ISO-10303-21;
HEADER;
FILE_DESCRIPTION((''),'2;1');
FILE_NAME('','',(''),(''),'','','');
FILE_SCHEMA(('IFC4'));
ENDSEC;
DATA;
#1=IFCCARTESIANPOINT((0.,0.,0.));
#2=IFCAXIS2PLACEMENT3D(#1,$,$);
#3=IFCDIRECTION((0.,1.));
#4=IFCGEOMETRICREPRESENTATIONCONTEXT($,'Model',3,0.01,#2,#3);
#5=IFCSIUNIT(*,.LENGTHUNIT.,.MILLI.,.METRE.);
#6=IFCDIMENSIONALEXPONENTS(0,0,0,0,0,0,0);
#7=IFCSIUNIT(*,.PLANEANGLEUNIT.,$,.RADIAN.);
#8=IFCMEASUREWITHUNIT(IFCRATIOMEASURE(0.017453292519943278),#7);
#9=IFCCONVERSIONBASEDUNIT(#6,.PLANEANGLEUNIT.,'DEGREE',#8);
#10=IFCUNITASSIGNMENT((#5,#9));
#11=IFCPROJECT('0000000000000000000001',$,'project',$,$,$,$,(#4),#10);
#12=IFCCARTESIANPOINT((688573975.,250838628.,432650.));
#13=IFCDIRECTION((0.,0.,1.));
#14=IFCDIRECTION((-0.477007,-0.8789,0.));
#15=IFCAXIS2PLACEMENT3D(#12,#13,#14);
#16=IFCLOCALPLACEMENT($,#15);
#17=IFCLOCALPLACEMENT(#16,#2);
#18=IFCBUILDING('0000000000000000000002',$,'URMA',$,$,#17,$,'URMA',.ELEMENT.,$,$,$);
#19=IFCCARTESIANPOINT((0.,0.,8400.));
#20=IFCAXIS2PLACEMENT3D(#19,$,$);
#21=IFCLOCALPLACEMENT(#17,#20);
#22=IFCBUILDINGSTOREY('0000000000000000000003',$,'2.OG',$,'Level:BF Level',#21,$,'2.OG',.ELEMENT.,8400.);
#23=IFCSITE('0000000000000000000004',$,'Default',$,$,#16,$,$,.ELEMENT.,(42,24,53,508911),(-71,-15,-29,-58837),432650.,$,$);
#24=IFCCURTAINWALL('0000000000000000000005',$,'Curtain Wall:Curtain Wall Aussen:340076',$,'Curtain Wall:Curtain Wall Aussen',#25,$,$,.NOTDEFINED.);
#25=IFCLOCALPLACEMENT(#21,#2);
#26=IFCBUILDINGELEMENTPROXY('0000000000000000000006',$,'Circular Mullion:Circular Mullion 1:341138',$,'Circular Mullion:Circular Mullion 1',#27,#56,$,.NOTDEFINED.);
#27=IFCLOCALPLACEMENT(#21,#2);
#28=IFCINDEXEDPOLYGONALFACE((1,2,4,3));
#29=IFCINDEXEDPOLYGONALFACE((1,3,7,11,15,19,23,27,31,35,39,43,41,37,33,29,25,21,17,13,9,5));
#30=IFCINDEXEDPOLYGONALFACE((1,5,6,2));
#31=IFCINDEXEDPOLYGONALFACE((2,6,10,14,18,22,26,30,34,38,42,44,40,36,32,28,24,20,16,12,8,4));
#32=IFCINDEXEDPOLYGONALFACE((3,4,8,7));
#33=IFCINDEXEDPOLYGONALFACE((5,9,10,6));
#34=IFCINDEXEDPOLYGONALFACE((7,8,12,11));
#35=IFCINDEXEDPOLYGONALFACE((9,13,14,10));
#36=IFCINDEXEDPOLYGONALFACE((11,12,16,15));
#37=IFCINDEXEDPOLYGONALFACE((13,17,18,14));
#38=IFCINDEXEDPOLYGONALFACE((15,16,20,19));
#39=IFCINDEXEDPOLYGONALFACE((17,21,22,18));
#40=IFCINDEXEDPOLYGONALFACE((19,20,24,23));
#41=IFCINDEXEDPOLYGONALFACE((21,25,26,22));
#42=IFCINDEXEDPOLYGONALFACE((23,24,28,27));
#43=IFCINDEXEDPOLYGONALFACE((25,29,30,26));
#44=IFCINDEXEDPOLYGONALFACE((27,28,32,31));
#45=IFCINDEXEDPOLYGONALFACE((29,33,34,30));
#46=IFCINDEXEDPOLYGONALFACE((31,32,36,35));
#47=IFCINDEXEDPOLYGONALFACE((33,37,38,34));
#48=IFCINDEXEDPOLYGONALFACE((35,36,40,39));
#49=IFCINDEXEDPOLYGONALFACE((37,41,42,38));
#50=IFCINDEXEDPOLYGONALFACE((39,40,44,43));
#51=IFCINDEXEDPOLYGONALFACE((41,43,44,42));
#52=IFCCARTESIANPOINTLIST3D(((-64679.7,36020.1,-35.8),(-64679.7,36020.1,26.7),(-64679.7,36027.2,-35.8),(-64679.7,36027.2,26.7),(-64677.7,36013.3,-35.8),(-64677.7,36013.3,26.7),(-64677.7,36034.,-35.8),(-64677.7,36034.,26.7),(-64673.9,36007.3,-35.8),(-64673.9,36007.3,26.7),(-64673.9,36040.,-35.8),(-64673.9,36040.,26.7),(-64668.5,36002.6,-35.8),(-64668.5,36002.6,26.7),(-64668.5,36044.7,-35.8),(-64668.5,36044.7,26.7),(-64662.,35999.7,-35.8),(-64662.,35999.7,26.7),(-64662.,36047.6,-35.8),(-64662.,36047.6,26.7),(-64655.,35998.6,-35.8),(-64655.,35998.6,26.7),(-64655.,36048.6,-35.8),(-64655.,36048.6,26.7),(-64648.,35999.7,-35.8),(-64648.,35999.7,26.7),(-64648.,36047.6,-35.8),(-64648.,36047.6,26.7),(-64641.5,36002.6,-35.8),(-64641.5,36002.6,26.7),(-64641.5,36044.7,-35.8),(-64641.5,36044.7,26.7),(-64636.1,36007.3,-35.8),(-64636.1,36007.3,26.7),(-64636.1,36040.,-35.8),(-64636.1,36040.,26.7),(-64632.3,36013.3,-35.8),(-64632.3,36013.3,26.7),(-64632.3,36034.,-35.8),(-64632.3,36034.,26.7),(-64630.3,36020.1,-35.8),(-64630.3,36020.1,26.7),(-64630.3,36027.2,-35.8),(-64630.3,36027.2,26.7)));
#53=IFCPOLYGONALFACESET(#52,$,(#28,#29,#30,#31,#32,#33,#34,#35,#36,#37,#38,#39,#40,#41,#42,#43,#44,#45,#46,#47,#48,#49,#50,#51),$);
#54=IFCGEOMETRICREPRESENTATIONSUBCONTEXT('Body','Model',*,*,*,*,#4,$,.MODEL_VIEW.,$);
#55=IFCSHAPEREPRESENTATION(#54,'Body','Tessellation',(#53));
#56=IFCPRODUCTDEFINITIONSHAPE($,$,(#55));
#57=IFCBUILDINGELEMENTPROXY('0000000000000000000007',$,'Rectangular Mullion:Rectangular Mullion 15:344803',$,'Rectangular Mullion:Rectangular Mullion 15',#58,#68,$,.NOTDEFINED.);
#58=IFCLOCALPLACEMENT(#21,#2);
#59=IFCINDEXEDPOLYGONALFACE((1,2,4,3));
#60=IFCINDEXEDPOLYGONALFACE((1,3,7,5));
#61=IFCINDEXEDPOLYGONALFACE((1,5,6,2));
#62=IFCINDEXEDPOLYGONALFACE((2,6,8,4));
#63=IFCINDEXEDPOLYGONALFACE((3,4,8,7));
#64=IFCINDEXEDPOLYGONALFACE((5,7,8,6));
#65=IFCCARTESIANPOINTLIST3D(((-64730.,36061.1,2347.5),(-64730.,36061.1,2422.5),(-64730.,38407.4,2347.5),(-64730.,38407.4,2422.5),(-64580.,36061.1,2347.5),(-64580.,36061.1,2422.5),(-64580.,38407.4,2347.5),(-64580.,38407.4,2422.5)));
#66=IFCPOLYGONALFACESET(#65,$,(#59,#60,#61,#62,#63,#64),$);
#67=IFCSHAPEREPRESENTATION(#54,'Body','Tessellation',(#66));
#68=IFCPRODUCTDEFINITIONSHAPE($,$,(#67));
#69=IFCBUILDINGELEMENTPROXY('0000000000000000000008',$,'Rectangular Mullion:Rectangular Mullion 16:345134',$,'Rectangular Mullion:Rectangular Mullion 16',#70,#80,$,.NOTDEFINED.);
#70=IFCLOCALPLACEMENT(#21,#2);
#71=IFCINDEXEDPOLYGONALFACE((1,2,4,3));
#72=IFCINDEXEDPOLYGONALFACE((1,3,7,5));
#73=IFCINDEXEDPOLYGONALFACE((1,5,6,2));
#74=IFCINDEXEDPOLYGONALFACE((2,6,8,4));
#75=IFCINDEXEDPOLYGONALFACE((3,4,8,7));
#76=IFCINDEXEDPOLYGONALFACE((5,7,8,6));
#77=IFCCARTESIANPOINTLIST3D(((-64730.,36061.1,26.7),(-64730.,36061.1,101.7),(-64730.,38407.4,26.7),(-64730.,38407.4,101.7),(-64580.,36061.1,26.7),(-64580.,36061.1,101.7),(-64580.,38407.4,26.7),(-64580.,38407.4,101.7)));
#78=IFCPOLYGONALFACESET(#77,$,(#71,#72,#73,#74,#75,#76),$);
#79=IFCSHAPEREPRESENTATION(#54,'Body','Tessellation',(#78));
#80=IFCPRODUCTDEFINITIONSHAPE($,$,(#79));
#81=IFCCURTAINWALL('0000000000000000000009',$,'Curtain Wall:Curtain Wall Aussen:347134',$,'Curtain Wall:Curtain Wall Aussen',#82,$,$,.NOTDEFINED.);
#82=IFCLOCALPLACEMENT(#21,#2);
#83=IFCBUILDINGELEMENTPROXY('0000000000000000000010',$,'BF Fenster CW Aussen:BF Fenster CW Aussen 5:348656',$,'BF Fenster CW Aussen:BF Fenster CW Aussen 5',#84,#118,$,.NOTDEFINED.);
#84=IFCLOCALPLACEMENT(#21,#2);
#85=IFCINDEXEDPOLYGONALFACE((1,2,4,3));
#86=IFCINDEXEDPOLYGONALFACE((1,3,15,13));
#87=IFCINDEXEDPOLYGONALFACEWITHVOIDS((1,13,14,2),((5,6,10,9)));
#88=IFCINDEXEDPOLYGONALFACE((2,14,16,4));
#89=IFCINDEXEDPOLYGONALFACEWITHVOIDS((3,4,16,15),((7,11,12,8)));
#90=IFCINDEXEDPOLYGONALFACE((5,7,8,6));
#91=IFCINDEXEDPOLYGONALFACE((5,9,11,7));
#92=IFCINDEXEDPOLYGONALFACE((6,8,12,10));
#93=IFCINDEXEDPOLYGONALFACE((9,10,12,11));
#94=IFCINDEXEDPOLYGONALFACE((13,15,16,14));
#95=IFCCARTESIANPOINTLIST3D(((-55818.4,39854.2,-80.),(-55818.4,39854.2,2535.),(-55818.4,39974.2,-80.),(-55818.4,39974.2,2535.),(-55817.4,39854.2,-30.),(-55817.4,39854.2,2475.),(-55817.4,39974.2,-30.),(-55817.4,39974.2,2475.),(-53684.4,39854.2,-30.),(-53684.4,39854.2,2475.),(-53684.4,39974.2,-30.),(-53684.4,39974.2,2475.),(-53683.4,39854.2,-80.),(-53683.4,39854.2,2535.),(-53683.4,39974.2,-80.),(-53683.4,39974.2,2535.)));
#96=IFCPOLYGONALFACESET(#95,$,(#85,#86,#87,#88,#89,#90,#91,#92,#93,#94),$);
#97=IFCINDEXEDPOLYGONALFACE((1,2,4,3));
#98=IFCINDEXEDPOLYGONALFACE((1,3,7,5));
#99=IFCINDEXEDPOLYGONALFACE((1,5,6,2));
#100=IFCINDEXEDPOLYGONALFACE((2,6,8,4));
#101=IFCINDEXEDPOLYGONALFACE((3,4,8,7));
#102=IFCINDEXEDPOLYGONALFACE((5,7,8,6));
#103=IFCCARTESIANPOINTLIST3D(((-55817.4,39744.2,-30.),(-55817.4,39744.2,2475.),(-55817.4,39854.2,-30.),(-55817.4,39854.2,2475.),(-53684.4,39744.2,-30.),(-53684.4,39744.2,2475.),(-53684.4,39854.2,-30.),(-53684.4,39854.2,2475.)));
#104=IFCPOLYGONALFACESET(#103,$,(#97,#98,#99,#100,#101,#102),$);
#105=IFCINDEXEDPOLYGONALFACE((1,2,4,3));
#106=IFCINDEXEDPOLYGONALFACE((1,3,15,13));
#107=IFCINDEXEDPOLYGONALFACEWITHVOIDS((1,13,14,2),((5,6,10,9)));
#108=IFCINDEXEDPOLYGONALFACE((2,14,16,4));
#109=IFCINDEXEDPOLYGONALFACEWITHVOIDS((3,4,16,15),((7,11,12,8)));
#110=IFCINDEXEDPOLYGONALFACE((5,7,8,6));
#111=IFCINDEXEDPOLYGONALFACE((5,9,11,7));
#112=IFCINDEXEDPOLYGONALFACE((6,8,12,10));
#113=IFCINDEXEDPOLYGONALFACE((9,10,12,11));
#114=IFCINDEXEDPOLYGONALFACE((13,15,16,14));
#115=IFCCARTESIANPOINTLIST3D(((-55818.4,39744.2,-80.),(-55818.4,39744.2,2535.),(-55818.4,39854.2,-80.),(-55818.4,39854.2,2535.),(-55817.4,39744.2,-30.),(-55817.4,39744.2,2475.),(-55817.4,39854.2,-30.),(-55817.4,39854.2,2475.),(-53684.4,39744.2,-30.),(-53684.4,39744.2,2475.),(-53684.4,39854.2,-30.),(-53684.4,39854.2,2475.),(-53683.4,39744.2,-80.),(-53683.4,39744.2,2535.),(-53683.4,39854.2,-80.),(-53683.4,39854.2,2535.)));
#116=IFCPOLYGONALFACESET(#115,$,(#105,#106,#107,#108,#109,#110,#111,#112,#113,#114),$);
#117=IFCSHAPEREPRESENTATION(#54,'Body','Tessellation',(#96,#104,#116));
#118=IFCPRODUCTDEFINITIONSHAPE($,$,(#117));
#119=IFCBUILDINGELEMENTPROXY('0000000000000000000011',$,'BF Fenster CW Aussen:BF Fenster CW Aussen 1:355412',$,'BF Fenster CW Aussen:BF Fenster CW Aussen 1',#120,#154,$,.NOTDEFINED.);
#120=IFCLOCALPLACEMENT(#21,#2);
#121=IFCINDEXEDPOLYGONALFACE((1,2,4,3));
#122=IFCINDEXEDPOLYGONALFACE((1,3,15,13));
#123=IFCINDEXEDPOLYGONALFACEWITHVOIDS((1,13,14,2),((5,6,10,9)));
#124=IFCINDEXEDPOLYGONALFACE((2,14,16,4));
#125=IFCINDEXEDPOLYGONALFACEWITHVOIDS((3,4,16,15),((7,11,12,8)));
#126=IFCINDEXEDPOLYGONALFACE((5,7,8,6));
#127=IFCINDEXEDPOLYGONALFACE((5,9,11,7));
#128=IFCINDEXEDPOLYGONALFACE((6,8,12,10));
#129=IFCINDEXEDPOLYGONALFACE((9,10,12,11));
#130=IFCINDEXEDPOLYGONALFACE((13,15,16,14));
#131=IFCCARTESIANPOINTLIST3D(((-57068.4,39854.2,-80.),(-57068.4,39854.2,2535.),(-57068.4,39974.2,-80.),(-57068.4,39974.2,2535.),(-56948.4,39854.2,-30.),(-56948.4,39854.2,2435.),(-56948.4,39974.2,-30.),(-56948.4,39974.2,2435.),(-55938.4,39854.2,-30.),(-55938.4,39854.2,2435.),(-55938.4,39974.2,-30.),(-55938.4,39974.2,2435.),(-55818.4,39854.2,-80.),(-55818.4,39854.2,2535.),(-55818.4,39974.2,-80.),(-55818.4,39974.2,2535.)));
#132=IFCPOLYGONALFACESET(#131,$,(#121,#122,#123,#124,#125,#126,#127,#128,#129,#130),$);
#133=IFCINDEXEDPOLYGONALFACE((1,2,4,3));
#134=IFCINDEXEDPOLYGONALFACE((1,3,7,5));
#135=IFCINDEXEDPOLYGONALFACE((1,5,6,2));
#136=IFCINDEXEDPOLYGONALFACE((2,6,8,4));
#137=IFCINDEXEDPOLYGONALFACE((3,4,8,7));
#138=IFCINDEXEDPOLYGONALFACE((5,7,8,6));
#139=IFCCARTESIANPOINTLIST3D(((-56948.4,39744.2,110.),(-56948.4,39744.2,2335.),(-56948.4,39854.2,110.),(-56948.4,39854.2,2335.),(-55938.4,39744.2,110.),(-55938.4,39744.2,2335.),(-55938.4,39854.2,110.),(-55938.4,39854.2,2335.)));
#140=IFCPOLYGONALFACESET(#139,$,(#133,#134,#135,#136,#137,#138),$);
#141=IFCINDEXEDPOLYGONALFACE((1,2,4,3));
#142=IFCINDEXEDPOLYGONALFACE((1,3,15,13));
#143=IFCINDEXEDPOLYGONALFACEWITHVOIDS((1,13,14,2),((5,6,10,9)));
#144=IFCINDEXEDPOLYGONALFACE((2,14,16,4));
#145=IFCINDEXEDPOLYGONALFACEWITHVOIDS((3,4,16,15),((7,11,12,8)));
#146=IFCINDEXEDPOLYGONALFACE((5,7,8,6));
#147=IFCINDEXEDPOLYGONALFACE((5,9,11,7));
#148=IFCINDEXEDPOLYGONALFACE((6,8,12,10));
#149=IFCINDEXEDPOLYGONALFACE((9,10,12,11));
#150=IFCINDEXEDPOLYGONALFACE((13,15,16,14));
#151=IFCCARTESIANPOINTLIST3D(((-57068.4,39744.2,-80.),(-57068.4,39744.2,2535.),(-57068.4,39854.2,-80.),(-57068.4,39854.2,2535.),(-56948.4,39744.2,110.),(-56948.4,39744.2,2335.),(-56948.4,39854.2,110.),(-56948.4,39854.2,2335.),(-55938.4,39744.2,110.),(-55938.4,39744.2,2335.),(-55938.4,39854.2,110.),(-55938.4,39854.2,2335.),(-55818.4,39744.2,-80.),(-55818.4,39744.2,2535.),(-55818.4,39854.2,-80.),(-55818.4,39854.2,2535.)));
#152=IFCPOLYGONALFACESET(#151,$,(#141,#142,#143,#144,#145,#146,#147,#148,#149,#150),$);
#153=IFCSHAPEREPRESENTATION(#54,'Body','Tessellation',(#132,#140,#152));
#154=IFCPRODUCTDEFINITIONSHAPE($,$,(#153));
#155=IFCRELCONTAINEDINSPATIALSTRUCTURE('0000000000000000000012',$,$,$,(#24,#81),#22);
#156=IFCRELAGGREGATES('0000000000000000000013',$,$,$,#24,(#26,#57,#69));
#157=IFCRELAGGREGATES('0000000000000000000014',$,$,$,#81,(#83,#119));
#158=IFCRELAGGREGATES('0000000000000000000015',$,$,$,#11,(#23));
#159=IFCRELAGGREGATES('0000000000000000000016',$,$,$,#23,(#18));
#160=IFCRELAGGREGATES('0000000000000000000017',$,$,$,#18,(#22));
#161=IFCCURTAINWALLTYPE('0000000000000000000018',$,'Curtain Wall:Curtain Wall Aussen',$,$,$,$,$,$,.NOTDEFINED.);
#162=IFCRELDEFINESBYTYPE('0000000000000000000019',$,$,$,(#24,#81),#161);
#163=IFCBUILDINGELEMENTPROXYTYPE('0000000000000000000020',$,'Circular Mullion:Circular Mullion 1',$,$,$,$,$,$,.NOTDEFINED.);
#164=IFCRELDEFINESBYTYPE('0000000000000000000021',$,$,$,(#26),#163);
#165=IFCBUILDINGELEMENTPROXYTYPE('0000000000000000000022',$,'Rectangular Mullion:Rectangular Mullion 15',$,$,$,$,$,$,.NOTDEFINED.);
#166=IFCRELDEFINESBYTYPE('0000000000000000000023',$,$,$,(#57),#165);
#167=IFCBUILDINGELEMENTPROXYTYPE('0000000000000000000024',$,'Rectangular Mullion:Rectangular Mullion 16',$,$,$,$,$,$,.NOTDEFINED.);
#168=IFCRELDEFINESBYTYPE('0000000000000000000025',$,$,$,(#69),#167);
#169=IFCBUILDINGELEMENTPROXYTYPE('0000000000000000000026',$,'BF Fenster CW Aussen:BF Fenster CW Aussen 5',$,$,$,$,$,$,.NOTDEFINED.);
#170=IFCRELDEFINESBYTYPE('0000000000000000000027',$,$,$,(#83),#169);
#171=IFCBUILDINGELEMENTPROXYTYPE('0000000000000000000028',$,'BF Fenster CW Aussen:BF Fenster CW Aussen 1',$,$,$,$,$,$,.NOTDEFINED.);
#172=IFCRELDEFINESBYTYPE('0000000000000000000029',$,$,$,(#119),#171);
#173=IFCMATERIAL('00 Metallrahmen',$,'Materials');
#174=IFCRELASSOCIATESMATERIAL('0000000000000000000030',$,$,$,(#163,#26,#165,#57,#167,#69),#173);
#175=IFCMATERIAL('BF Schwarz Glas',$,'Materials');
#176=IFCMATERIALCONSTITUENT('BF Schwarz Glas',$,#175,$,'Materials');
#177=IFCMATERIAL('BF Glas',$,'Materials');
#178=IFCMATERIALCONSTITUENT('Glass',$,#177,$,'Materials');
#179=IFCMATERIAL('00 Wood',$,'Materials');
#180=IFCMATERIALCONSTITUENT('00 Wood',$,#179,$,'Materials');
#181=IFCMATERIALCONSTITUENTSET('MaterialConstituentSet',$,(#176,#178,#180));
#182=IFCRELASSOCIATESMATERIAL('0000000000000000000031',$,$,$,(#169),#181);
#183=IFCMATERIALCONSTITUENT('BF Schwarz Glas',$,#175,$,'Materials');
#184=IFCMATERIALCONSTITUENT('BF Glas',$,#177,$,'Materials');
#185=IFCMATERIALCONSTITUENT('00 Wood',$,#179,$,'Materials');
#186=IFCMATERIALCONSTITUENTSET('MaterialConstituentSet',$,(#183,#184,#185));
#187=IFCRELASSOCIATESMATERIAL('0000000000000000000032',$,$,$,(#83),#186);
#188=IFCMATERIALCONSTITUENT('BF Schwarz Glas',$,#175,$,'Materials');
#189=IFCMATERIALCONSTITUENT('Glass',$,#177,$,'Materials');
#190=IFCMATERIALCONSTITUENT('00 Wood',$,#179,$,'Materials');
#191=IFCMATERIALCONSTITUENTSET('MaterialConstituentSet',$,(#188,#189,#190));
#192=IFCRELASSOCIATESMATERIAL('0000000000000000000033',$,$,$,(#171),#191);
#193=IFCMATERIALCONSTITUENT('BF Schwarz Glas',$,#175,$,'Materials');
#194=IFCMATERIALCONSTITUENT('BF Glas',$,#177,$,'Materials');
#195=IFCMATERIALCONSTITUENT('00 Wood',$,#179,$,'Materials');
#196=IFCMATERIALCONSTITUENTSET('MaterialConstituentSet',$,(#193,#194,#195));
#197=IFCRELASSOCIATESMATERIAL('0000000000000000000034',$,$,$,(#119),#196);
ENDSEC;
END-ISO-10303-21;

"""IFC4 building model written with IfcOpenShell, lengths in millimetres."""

from ifc_helpers import new_model, entity, si_unit, converted_unit, direction, frame, origin, place, context, subcontext, project, spatial, arc, indexed_curve, outline, extrude, source, transform, mapped, material, constituent, constituent_set, type_object, type_shapes, element, aggregate, save


model = new_model("IFC4")

# Units and contexts
model_context = context("Model", 3, precision=0.01, world=origin(), true_north=direction((0.0, 1.0)))
body_context = subcontext(model_context, "Body", "Model", "MODEL_VIEW")
ifc_project = project(units=[si_unit("LENGTHUNIT", "METRE", prefix="MILLI"), converted_unit("PLANEANGLEUNIT", "DEGREE", entity("IfcRatioMeasure", 0.017453292519943278), si_unit("PLANEANGLEUNIT", "RADIAN"), dimensions=[0, 0, 0, 0, 0, 0, 0])], contexts=[model_context])

# Site, building, storey
site_placement = place(None, frame((688573975.0, 250838628.0, 432650.0), z_axis=(0.0, 0.0, 1.0), x_axis=(-0.477007, -0.8789, 0.0)))
site = spatial("IfcSite", under=ifc_project, at=site_placement, Name="Default", CompositionType="ELEMENT", RefLatitude=(42, 24, 53, 508911), RefLongitude=(-71, -15, -29, -58837), RefElevation=432650.0)
building_placement = place(site_placement, origin())
building = spatial("IfcBuilding", under=site, at=building_placement, Name="URMA", LongName="URMA", CompositionType="ELEMENT")
storey_placement = place(building_placement, frame((0.0, 0.0, 8400.0)))
storey = spatial("IfcBuildingStorey", under=building, at=storey_placement, Name="2.OG", ObjectType="Level:BF Level", LongName="2.OG", CompositionType="ELEMENT", Elevation=8400.0)

# Shared definitions
curtain_wall_type = type_object("IfcCurtainWallType", Name="Curtain Wall:Curtain Wall Aussen", PredefinedType="NOTDEFINED")

# Curtain walls, building element proxies
curtain_wall_1_placement = place(storey_placement, frame((0.0, 0.0, -8400.0)))
curtain_wall_1 = element("IfcCurtainWall", 1, at=curtain_wall_1_placement, inside=storey, type_object=curtain_wall_type, Name="Curtain Wall:Curtain Wall Aussen:340076", ObjectType="Curtain Wall:Curtain Wall Aussen", PredefinedType="NOTDEFINED")
ifc_material_1 = material(Name="00 Metallrahmen", Category="Materials")
building_element_proxy_type_1 = type_object("IfcBuildingElementProxyType", Name="Circular Mullion:Circular Mullion 1", PredefinedType="NOTDEFINED", material=ifc_material_1)
shared_shape_1 = source(origin(), body_context, "Body", "SweptSolid", [
    extrude(outline(indexed_curve([(25.0, 0.0), (0.0, 25.0), (-25.0, 0.0), (0.0, -25.0)], segments=[arc(1, 2, 3), arc(3, 4, 1)], self_intersect=False)), frame((0.0, 0.0, -62.5)), (0.0, 0.0, 1.0), 62.5),
])
type_shapes(building_element_proxy_type_1, [shared_shape_1])
proxy_1_placement = place(storey_placement, frame((-64655.0, 36023.6, -35.8), z_axis=(0.0, 0.0, -1.0), x_axis=(0.0, -1.0, 0.0)))
proxy_1 = element("IfcBuildingElementProxy", 2, at=proxy_1_placement, type_object=building_element_proxy_type_1, material=ifc_material_1, Name="Circular Mullion:Circular Mullion 1:341138", ObjectType="Circular Mullion:Circular Mullion 1", PredefinedType="NOTDEFINED", context=body_context, shape_type="MappedRepresentation", body=[
    mapped(shared_shape_1, transform((0.0, 0.0, 0.0), scale=1.0)),
])
building_element_proxy_type_2 = type_object("IfcBuildingElementProxyType", Name="Rectangular Mullion:Rectangular Mullion 15", PredefinedType="NOTDEFINED", material=ifc_material_1)
shared_shape_2 = source(origin(), body_context, "Body", "SweptSolid", [
    extrude(outline(indexed_curve([(-37.5, -75.0), (37.5, -75.0), (37.5, 75.0), (-37.5, 75.0), (-37.5, -75.0)], self_intersect=False)), frame((-37.5, 0.0, -2346.2), z_axis=(0.0, 0.0, 1.0), x_axis=(-1.0, 0.0, 0.0)), (0.0, 0.0, 1.0), 2346.2),
])
type_shapes(building_element_proxy_type_2, [shared_shape_2])
proxy_2_placement = place(storey_placement, frame((-64655.0, 36061.1, 2422.5), z_axis=(0.0, -1.0, 0.0), x_axis=(0.0, 0.0, 1.0)))
proxy_2 = element("IfcBuildingElementProxy", 3, at=proxy_2_placement, type_object=building_element_proxy_type_2, material=ifc_material_1, Name="Rectangular Mullion:Rectangular Mullion 15:344803", ObjectType="Rectangular Mullion:Rectangular Mullion 15", PredefinedType="NOTDEFINED", context=body_context, shape_type="MappedRepresentation", body=[
    mapped(shared_shape_2, transform((0.0, 0.0, 0.0), scale=1.0)),
])
building_element_proxy_type_3 = type_object("IfcBuildingElementProxyType", Name="Rectangular Mullion:Rectangular Mullion 16", PredefinedType="NOTDEFINED", material=ifc_material_1)
shared_shape_3 = source(origin(), body_context, "Body", "SweptSolid", [
    extrude(outline(indexed_curve([(-37.5, -75.0), (37.5, -75.0), (37.5, 75.0), (-37.5, 75.0), (-37.5, -75.0)], self_intersect=False)), frame((37.5, 0.0, -2346.2), z_axis=(0.0, 0.0, 1.0), x_axis=(-1.0, 0.0, 0.0)), (0.0, 0.0, 1.0), 2346.2),
])
type_shapes(building_element_proxy_type_3, [shared_shape_3])
proxy_3_placement = place(storey_placement, frame((-64655.0, 36061.1, 26.7), z_axis=(0.0, -1.0, 0.0), x_axis=(0.0, 0.0, 1.0)))
proxy_3 = element("IfcBuildingElementProxy", 4, at=proxy_3_placement, type_object=building_element_proxy_type_3, material=ifc_material_1, Name="Rectangular Mullion:Rectangular Mullion 16:345134", ObjectType="Rectangular Mullion:Rectangular Mullion 16", PredefinedType="NOTDEFINED", context=body_context, shape_type="MappedRepresentation", body=[
    mapped(shared_shape_3, transform((0.0, 0.0, 0.0), scale=1.0)),
])
aggregate(curtain_wall_1, [proxy_1, proxy_2, proxy_3])
curtain_wall_2_placement = place(storey_placement, frame((0.0, 0.0, -8400.0)))
curtain_wall_2 = element("IfcCurtainWall", 5, at=curtain_wall_2_placement, inside=storey, type_object=curtain_wall_type, Name="Curtain Wall:Curtain Wall Aussen:347134", ObjectType="Curtain Wall:Curtain Wall Aussen", PredefinedType="NOTDEFINED")
ifc_material_2 = material(Name="BF Schwarz Glas", Category="Materials")
ifc_constituent_1 = constituent(ifc_material_2, Name="BF Schwarz Glas", Category="Materials")
ifc_material_3 = material(Name="BF Glas", Category="Materials")
ifc_constituent_2 = constituent(ifc_material_3, Name="BF Glas", Category="Materials")
ifc_material_4 = material(Name="00 Wood", Category="Materials")
ifc_constituent_3 = constituent(ifc_material_4, Name="00 Wood", Category="Materials")
ifc_constituent_set_1 = constituent_set(constituents=[ifc_constituent_1, ifc_constituent_2, ifc_constituent_3], Name="MaterialConstituentSet")
ifc_constituent_4 = constituent(ifc_material_2, Name="BF Schwarz Glas", Category="Materials")
ifc_constituent_5 = constituent(ifc_material_3, Name="Glass", Category="Materials")
ifc_constituent_6 = constituent(ifc_material_4, Name="00 Wood", Category="Materials")
ifc_constituent_set_2 = constituent_set(constituents=[ifc_constituent_4, ifc_constituent_5, ifc_constituent_6], Name="MaterialConstituentSet")
building_element_proxy_type_4 = type_object("IfcBuildingElementProxyType", Name="BF Fenster CW Aussen:BF Fenster CW Aussen 5", PredefinedType="NOTDEFINED", material=ifc_constituent_set_2)
shared_shape_4 = source(origin(), body_context, "Body", "SweptSolid", [
    extrude(outline(indexed_curve([(-1067.5, -1307.5), (1067.5, -1307.5), (1067.5, 1307.5), (-1067.5, 1307.5), (-1067.5, -1307.5)], self_intersect=False), holes=[indexed_curve([(-1066.5, -1247.5), (-1066.5, 1257.5), (1066.5, 1257.5), (1066.5, -1247.5), (-1066.5, -1247.5)], self_intersect=False)]), frame((0.0, -120.0, 1307.5), z_axis=(0.0, 1.0, 0.0), x_axis=(1.0, 0.0, 0.0)), (0.0, 0.0, 1.0), 120.0),
    extrude(outline(indexed_curve([(-55.0, -1066.5), (55.0, -1066.5), (55.0, 1066.5), (-55.0, 1066.5), (-55.0, -1066.5)], self_intersect=False)), frame((0.0, 55.0, 50.0), z_axis=(0.0, 0.0, 1.0), x_axis=(0.0, 1.0, 0.0)), (0.0, 0.0, 1.0), 2505.0),
    extrude(outline(indexed_curve([(-1067.5, -1307.5), (1067.5, -1307.5), (1067.5, 1307.5), (-1067.5, 1307.5), (-1067.5, -1307.5)], self_intersect=False), holes=[indexed_curve([(-1066.5, -1247.5), (-1066.5, 1257.5), (1066.5, 1257.5), (1066.5, -1247.5), (-1066.5, -1247.5)], self_intersect=False)]), frame((0.0, 0.0, 1307.5), z_axis=(0.0, 1.0, 0.0), x_axis=(1.0, 0.0, 0.0)), (0.0, 0.0, 1.0), 110.0),
])
type_shapes(building_element_proxy_type_4, [shared_shape_4])
proxy_4_placement = place(storey_placement, frame((-54750.9, 39854.2, -80.0), z_axis=(0.0, 0.0, 1.0), x_axis=(-1.0, 0.0, 0.0)))
proxy_4 = element("IfcBuildingElementProxy", 6, at=proxy_4_placement, type_object=building_element_proxy_type_4, material=ifc_constituent_set_1, Name="BF Fenster CW Aussen:BF Fenster CW Aussen 5:348656", ObjectType="BF Fenster CW Aussen:BF Fenster CW Aussen 5", PredefinedType="NOTDEFINED", context=body_context, shape_type="MappedRepresentation", body=[
    mapped(shared_shape_4, transform((0.0, 0.0, 0.0), scale=1.0)),
])
ifc_constituent_7 = constituent(ifc_material_2, Name="BF Schwarz Glas", Category="Materials")
ifc_constituent_8 = constituent(ifc_material_3, Name="BF Glas", Category="Materials")
ifc_constituent_9 = constituent(ifc_material_4, Name="00 Wood", Category="Materials")
ifc_constituent_set_3 = constituent_set(constituents=[ifc_constituent_7, ifc_constituent_8, ifc_constituent_9], Name="MaterialConstituentSet")
ifc_constituent_10 = constituent(ifc_material_2, Name="BF Schwarz Glas", Category="Materials")
ifc_constituent_11 = constituent(ifc_material_3, Name="Glass", Category="Materials")
ifc_constituent_12 = constituent(ifc_material_4, Name="00 Wood", Category="Materials")
ifc_constituent_set_4 = constituent_set(constituents=[ifc_constituent_10, ifc_constituent_11, ifc_constituent_12], Name="MaterialConstituentSet")
building_element_proxy_type_5 = type_object("IfcBuildingElementProxyType", Name="BF Fenster CW Aussen:BF Fenster CW Aussen 1", PredefinedType="NOTDEFINED", material=ifc_constituent_set_4)
shared_shape_5 = source(origin(), body_context, "Body", "SweptSolid", [
    extrude(outline(indexed_curve([(-625.0, -1307.5), (625.0, -1307.5), (625.0, 1307.5), (-625.0, 1307.5), (-625.0, -1307.5)], self_intersect=False), holes=[indexed_curve([(-505.0, -1207.5), (-505.0, 1257.5), (505.0, 1257.5), (505.0, -1207.5), (-505.0, -1207.5)], self_intersect=False)]), frame((0.0, -120.0, 1307.5), z_axis=(0.0, 1.0, 0.0), x_axis=(1.0, 0.0, 0.0)), (0.0, 0.0, 1.0), 120.0),
    extrude(outline(indexed_curve([(-55.0, -505.0), (55.0, -505.0), (55.0, 505.0), (-55.0, 505.0), (-55.0, -505.0)], self_intersect=False)), frame((0.0, 55.0, 190.0), z_axis=(0.0, 0.0, 1.0), x_axis=(0.0, 1.0, 0.0)), (0.0, 0.0, 1.0), 2225.0),
    extrude(outline(indexed_curve([(-625.0, -1307.5), (625.0, -1307.5), (625.0, 1307.5), (-625.0, 1307.5), (-625.0, -1307.5)], self_intersect=False), holes=[indexed_curve([(-505.0, -1107.5), (-505.0, 1117.5), (505.0, 1117.5), (505.0, -1107.5), (-505.0, -1107.5)], self_intersect=False)]), frame((0.0, 0.0, 1307.5), z_axis=(0.0, 1.0, 0.0), x_axis=(1.0, 0.0, 0.0)), (0.0, 0.0, 1.0), 110.0),
])
type_shapes(building_element_proxy_type_5, [shared_shape_5])
proxy_5_placement = place(storey_placement, frame((-56443.4, 39854.2, -80.0), z_axis=(0.0, 0.0, 1.0), x_axis=(-1.0, 0.0, 0.0)))
proxy_5 = element("IfcBuildingElementProxy", 7, at=proxy_5_placement, type_object=building_element_proxy_type_5, material=ifc_constituent_set_3, Name="BF Fenster CW Aussen:BF Fenster CW Aussen 1:355412", ObjectType="BF Fenster CW Aussen:BF Fenster CW Aussen 1", PredefinedType="NOTDEFINED", context=body_context, shape_type="MappedRepresentation", body=[
    mapped(shared_shape_5, transform((0.0, 0.0, 0.0), scale=1.0)),
])
aggregate(curtain_wall_2, [proxy_4, proxy_5])

save(model, "model.ifc")
